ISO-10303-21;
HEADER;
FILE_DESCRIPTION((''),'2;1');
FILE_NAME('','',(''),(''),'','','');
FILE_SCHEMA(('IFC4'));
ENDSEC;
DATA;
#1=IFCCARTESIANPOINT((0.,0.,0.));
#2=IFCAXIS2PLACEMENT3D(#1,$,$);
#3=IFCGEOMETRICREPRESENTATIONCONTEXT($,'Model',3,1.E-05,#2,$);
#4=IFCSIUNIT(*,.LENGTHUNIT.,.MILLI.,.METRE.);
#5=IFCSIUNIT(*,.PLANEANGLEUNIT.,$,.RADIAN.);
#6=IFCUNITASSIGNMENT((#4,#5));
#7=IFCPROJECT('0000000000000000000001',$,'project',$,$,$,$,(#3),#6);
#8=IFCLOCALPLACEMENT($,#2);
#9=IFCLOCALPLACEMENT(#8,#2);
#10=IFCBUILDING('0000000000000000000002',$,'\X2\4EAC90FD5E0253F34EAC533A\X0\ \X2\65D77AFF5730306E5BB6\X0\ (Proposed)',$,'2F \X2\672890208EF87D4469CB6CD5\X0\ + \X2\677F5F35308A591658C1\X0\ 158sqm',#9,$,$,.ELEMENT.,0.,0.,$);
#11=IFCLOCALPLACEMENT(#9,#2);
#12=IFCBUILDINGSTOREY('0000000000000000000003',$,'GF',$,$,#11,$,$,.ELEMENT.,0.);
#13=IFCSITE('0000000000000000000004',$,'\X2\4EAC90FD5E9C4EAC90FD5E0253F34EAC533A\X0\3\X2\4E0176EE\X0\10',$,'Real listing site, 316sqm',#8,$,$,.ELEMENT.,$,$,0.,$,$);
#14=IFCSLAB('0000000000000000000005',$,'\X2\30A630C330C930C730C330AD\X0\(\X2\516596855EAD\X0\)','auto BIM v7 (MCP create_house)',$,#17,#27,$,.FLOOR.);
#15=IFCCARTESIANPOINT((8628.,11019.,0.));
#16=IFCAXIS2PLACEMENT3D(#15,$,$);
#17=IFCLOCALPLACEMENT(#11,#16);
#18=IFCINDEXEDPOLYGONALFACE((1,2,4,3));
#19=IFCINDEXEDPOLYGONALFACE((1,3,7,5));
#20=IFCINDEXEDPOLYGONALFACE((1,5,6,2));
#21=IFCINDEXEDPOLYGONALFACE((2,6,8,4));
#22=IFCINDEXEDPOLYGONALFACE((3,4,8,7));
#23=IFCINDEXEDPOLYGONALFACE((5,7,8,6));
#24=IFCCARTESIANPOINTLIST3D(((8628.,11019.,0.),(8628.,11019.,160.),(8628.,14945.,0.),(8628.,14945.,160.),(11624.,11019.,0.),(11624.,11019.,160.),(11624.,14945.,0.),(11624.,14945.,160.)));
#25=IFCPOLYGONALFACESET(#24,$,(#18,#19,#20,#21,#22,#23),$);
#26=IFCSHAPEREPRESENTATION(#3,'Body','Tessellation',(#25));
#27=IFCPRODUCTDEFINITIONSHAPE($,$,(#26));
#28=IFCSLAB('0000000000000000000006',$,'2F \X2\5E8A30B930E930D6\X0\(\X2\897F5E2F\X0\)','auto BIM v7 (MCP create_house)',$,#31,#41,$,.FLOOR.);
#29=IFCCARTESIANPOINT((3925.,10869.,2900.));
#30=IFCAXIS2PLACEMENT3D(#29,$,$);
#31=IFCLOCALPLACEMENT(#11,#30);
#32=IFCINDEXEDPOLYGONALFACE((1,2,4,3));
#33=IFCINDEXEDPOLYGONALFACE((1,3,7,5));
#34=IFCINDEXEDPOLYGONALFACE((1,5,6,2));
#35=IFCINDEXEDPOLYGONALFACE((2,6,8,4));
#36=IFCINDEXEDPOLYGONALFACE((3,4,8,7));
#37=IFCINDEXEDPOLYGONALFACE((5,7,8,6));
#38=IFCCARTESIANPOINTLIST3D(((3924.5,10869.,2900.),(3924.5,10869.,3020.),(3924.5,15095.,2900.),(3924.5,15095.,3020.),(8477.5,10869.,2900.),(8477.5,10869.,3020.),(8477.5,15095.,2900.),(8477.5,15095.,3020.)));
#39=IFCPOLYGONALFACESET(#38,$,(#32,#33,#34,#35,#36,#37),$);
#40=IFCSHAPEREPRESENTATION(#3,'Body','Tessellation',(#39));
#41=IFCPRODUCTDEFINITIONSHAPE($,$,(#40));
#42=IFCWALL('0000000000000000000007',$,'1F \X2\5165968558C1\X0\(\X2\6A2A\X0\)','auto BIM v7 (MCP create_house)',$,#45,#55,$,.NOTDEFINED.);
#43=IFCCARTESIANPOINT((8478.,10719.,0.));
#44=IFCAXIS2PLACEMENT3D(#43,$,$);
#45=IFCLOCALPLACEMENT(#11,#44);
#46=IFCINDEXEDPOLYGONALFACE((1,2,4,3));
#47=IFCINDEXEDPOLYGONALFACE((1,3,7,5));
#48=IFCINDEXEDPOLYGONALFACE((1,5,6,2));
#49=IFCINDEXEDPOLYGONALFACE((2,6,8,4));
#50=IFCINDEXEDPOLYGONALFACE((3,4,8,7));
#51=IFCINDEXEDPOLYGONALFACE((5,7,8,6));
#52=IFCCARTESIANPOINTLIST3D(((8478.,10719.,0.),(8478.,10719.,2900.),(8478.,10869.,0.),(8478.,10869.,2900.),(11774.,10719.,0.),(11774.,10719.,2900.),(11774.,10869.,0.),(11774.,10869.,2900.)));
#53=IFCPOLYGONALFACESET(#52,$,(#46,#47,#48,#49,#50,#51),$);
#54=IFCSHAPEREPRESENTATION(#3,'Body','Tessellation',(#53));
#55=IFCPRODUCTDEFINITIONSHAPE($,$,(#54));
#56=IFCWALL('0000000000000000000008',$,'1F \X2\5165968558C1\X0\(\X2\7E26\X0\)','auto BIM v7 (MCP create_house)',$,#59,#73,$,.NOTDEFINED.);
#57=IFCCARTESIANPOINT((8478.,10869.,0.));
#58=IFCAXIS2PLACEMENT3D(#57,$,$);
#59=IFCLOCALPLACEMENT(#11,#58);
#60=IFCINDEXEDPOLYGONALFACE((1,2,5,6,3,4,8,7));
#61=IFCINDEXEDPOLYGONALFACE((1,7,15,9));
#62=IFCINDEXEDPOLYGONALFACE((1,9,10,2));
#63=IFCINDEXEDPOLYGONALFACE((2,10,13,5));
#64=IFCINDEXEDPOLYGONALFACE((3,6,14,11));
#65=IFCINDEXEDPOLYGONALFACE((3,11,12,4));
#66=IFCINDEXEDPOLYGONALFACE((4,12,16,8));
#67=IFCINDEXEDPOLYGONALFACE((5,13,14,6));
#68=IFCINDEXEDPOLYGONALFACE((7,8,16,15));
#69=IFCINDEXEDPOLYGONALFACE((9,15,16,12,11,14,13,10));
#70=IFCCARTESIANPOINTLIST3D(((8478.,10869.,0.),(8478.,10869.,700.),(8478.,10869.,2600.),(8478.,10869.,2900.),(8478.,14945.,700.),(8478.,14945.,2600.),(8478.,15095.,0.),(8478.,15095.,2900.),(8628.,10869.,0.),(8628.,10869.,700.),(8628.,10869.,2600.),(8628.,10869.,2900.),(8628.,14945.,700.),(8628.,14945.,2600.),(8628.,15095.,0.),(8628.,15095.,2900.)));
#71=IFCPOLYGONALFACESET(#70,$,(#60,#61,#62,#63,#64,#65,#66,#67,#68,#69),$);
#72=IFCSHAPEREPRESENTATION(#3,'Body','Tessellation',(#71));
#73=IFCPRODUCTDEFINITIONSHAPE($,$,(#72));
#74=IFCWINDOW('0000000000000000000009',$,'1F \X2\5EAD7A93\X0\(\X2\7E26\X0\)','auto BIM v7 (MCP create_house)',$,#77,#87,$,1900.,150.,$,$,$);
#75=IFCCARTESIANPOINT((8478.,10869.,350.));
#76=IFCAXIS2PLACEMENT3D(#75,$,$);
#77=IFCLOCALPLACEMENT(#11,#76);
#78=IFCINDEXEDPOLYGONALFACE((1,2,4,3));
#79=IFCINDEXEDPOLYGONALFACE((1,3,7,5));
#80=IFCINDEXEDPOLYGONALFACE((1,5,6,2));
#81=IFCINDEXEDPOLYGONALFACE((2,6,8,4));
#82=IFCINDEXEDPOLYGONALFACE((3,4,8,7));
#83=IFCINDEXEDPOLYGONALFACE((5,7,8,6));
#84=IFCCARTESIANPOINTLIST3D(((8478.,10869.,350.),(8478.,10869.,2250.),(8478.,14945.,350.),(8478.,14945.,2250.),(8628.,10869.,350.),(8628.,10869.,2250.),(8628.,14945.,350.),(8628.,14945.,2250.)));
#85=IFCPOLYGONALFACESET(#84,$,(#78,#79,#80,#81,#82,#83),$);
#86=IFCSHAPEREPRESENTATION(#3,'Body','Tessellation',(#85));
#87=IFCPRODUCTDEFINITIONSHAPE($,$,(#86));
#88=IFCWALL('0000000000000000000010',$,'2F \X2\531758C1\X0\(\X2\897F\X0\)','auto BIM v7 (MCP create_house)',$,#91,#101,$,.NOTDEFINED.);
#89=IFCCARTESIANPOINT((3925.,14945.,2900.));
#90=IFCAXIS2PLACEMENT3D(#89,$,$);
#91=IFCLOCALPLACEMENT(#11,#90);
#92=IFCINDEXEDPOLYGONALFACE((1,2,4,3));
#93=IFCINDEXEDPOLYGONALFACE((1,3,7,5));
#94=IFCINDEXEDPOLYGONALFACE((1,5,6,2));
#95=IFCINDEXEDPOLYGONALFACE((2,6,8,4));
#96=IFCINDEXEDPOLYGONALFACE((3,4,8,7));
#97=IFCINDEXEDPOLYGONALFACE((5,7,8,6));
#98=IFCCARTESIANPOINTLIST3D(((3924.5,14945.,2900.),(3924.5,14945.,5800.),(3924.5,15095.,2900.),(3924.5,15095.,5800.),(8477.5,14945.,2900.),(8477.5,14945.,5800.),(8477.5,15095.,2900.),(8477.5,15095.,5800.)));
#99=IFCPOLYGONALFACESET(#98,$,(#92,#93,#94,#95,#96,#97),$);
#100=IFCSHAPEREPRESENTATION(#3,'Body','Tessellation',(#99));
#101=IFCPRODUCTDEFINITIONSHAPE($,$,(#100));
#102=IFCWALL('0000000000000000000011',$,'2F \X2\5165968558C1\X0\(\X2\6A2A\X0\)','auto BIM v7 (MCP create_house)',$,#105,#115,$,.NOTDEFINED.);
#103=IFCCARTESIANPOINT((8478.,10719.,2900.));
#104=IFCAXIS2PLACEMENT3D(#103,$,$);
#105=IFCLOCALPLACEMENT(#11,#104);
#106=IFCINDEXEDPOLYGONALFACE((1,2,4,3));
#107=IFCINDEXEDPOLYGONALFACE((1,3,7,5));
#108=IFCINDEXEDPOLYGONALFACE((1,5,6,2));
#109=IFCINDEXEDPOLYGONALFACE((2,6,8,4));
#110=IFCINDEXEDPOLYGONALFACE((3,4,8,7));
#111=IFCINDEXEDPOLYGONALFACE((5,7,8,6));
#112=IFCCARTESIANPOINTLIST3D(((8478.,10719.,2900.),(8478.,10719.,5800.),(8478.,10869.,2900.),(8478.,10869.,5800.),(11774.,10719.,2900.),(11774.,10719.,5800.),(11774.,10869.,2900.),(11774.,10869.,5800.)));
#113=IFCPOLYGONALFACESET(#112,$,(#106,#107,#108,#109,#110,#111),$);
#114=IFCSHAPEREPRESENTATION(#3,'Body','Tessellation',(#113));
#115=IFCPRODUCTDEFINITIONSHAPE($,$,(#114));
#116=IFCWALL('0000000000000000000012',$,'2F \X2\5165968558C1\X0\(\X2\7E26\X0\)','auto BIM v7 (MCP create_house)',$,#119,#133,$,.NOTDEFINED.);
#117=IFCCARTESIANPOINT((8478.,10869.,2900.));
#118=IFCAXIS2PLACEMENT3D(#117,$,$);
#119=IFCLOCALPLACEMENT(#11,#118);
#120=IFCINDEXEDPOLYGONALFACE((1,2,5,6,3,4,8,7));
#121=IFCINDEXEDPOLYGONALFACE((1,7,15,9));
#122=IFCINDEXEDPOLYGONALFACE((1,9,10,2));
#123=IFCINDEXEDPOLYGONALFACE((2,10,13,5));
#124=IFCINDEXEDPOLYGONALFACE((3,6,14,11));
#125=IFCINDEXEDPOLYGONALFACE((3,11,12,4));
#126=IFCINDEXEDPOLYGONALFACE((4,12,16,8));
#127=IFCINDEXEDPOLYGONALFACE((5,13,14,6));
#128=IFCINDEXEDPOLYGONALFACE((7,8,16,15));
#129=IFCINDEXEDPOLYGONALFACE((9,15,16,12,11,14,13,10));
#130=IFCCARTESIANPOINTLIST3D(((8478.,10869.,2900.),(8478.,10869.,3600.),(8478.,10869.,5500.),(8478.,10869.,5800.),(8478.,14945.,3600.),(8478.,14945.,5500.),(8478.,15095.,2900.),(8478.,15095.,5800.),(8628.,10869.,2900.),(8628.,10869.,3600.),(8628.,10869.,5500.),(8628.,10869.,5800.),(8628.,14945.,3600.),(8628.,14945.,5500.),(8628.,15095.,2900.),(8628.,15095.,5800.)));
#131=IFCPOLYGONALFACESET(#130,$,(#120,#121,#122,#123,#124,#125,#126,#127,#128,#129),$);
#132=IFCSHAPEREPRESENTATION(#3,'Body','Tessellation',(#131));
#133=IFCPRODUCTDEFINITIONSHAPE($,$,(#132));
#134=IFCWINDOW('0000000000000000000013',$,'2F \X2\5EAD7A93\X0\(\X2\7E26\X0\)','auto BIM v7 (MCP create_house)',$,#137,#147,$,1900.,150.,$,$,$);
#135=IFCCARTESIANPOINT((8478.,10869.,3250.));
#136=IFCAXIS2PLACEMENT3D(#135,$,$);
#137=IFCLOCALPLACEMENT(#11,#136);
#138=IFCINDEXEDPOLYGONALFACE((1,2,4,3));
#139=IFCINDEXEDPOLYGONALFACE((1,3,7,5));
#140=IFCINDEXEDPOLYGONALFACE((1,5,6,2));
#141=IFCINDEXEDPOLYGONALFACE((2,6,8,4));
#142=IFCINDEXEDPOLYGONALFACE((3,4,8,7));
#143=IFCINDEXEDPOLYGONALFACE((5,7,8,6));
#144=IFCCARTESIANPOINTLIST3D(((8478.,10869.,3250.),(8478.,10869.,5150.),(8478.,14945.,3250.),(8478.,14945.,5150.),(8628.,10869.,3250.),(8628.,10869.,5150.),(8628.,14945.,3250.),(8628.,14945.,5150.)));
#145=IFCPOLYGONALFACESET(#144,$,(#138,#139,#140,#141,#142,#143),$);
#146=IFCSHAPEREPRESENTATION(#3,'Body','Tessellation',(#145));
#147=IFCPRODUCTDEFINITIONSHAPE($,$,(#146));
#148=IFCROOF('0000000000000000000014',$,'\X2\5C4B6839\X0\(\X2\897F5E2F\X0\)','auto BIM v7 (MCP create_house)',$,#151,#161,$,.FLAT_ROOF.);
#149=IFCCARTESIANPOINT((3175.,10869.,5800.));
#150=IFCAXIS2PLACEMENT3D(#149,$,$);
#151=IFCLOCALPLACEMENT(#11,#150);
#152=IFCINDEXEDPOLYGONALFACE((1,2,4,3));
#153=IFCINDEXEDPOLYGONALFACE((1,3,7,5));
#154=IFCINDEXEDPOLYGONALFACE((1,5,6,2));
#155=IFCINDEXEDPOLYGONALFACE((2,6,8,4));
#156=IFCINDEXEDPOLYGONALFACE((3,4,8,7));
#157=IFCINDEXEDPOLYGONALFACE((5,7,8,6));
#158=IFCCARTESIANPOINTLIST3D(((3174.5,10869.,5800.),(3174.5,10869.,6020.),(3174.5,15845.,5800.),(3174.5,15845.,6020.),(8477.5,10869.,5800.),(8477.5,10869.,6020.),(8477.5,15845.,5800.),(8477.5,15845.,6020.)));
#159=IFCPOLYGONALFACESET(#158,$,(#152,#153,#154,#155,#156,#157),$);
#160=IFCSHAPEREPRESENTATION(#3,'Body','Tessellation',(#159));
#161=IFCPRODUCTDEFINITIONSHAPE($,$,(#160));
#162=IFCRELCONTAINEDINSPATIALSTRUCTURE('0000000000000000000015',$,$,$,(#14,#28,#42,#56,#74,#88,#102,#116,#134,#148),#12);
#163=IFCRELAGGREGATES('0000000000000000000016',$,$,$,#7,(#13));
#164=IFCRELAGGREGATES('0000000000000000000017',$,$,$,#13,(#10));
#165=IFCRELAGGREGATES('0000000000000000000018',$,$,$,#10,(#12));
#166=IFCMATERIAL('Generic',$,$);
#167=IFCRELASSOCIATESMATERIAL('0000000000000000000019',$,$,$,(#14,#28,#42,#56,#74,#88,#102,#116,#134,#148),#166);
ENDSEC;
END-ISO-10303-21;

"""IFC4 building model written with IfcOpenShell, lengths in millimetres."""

from ifc_helpers import new_model, si_unit, frame, frame_2d, origin, place, context, project, spatial, rectangle, extrude, material, element, fill, save


model = new_model("IFC4")

# Units and contexts
model_context = context("Model", 3, precision=1e-05, world=origin())
ifc_project = project(units=[si_unit("LENGTHUNIT", "METRE", prefix="MILLI"), si_unit("PLANEANGLEUNIT", "RADIAN")], contexts=[model_context])

# Site, building, storey
site_placement = place(None, origin())
site = spatial("IfcSite", under=ifc_project, at=site_placement, Name="京都府京都市右京区3丁目10", ObjectType="Real listing site, 316sqm", CompositionType="ELEMENT", RefElevation=0.0)
building_placement = place(site_placement, origin())
building = spatial("IfcBuilding", under=site, at=building_placement, Name="京都市右京区 旗竿地の家 (Proposed)", ObjectType="2F 木造軸組構法 + 板張り外壁 158sqm", CompositionType="ELEMENT", ElevationOfRefHeight=0.0, ElevationOfTerrain=0.0)
storey_placement = place(building_placement, origin())
storey = spatial("IfcBuildingStorey", under=building, at=storey_placement, Name="GF", CompositionType="ELEMENT", Elevation=0.0)

# Slabs
ifc_material = material(Name="Generic")
slab_1_placement = place(storey_placement, frame((8628.0, 11019.0, 0.0)))
element("IfcSlab", 1, at=slab_1_placement, inside=storey, material=ifc_material, Name="ウッドデッキ(入隅庭)", Description="auto BIM v7 (MCP create_house)", PredefinedType="FLOOR", context=model_context, shape_type="SweptSolid", body=[
    extrude(rectangle(XDim=2996.0, YDim=3926.0, at=frame_2d((1498.0, 1963.0))), frame((8628.0, 11019.0, 0.0)), (0.0, 0.0, 1.0), 160.0),
])
slab_2_placement = place(storey_placement, frame((3925.0, 10869.0, 2900.0)))
element("IfcSlab", 2, at=slab_2_placement, inside=storey, material=ifc_material, Name="2F 床スラブ(西帯)", Description="auto BIM v7 (MCP create_house)", PredefinedType="FLOOR", context=model_context, shape_type="SweptSolid", body=[
    extrude(rectangle(XDim=4553.0, YDim=4226.0, at=frame_2d((2276.0, 2113.0))), frame((3925.0, 10869.0, 2900.0)), (0.0, 0.0, 1.0), 120.0),
])

# Wall
wall_1_placement = place(storey_placement, frame((8478.0, 10719.0, 0.0)))
element("IfcWall", 3, at=wall_1_placement, inside=storey, material=ifc_material, Name="1F 入隅壁(横)", Description="auto BIM v7 (MCP create_house)", PredefinedType="NOTDEFINED", context=model_context, shape_type="SweptSolid", body=[
    extrude(rectangle(XDim=3296.0, YDim=150.0, at=frame_2d((1648.0, 75.0))), frame((8478.0, 10719.0, 0.0)), (0.0, 0.0, 1.0), 2900.0),
])

# Wall, opening, window
wall_2_placement = place(storey_placement, frame((8478.0, 10869.0, 0.0)))
wall_2 = element("IfcWall", 4, at=wall_2_placement, inside=storey, material=ifc_material, Name="1F 入隅壁(縦)", Description="auto BIM v7 (MCP create_house)", PredefinedType="NOTDEFINED", context=model_context, shape_type="SweptSolid", body=[
    extrude(rectangle(XDim=150.0, YDim=4226.0, at=frame_2d((75.0, 2113.0))), frame((8478.0, 10869.0, 0.0)), (0.0, 0.0, 1.0), 2900.0),
])
opening_1_placement = place(storey_placement, frame((8478.0, 10869.0, 350.0)))
opening_1 = element("IfcOpeningElement", 5, at=opening_1_placement, cuts=wall_2, PredefinedType="NOTDEFINED", context=model_context, shape_type="SweptSolid", body=[
    extrude(rectangle(XDim=150.0, YDim=4076.0, at=frame_2d((75.0, 2038.0))), frame((8478.0, 10869.0, 350.0)), (0.0, 0.0, 1.0), 1900.0),
])
window_1_placement = place(storey_placement, frame((8478.0, 10869.0, 350.0)))
window_1 = element("IfcWindow", 6, at=window_1_placement, inside=storey, material=ifc_material, Name="1F 庭窓(縦)", Description="auto BIM v7 (MCP create_house)", OverallHeight=1900.0, OverallWidth=150.0, context=model_context, shape_type="SweptSolid", body=[
    extrude(rectangle(XDim=150.0, YDim=4076.0, at=frame_2d((75.0, 2038.0))), frame((8478.0, 10869.0, 350.0)), (0.0, 0.0, 1.0), 1900.0),
])
fill(opening_1, window_1)

# Walls
wall_3_placement = place(storey_placement, frame((3925.0, 14945.0, 2900.0)))
element("IfcWall", 7, at=wall_3_placement, inside=storey, material=ifc_material, Name="2F 北壁(西)", Description="auto BIM v7 (MCP create_house)", PredefinedType="NOTDEFINED", context=model_context, shape_type="SweptSolid", body=[
    extrude(rectangle(XDim=4553.0, YDim=150.0, at=frame_2d((2276.0, 75.0))), frame((3925.0, 14945.0, 2900.0)), (0.0, 0.0, 1.0), 2900.0),
])
wall_4_placement = place(storey_placement, frame((8478.0, 10719.0, 2900.0)))
element("IfcWall", 8, at=wall_4_placement, inside=storey, material=ifc_material, Name="2F 入隅壁(横)", Description="auto BIM v7 (MCP create_house)", PredefinedType="NOTDEFINED", context=model_context, shape_type="SweptSolid", body=[
    extrude(rectangle(XDim=3296.0, YDim=150.0, at=frame_2d((1648.0, 75.0))), frame((8478.0, 10719.0, 2900.0)), (0.0, 0.0, 1.0), 2900.0),
])

# Wall, opening, window
wall_5_placement = place(storey_placement, frame((8478.0, 10869.0, 2900.0)))
wall_5 = element("IfcWall", 9, at=wall_5_placement, inside=storey, material=ifc_material, Name="2F 入隅壁(縦)", Description="auto BIM v7 (MCP create_house)", PredefinedType="NOTDEFINED", context=model_context, shape_type="SweptSolid", body=[
    extrude(rectangle(XDim=150.0, YDim=4226.0, at=frame_2d((75.0, 2113.0))), frame((8478.0, 10869.0, 2900.0)), (0.0, 0.0, 1.0), 2900.0),
])
opening_2_placement = place(storey_placement, frame((8478.0, 10869.0, 3250.0)))
opening_2 = element("IfcOpeningElement", 10, at=opening_2_placement, cuts=wall_5, PredefinedType="NOTDEFINED", context=model_context, shape_type="SweptSolid", body=[
    extrude(rectangle(XDim=150.0, YDim=4076.0, at=frame_2d((75.0, 2038.0))), frame((8478.0, 10869.0, 3250.0)), (0.0, 0.0, 1.0), 1900.0),
])
window_2_placement = place(storey_placement, frame((8478.0, 10869.0, 3250.0)))
window_2 = element("IfcWindow", 11, at=window_2_placement, inside=storey, material=ifc_material, Name="2F 庭窓(縦)", Description="auto BIM v7 (MCP create_house)", OverallHeight=1900.0, OverallWidth=150.0, context=model_context, shape_type="SweptSolid", body=[
    extrude(rectangle(XDim=150.0, YDim=4076.0, at=frame_2d((75.0, 2038.0))), frame((8478.0, 10869.0, 3250.0)), (0.0, 0.0, 1.0), 1900.0),
])
fill(opening_2, window_2)

# Roof
for number, where, name in (
    (12, (3175.0, 10869.0, 5800.0), "屋根(西帯)"),
):
    element("IfcRoof", number, at=place(storey_placement, frame(where)), inside=storey, material=ifc_material, Name=name, Description="auto BIM v7 (MCP create_house)", PredefinedType="FLAT_ROOF", context=model_context, shape_type="SweptSolid", body=[
        extrude(rectangle(XDim=5303.0, YDim=4976.0, at=frame_2d((2651.0, 2488.0))), frame((3175.0, 10869.0, 5800.0)), (0.0, 0.0, 1.0), 220.0),
    ])

save(model, "model.ifc")
